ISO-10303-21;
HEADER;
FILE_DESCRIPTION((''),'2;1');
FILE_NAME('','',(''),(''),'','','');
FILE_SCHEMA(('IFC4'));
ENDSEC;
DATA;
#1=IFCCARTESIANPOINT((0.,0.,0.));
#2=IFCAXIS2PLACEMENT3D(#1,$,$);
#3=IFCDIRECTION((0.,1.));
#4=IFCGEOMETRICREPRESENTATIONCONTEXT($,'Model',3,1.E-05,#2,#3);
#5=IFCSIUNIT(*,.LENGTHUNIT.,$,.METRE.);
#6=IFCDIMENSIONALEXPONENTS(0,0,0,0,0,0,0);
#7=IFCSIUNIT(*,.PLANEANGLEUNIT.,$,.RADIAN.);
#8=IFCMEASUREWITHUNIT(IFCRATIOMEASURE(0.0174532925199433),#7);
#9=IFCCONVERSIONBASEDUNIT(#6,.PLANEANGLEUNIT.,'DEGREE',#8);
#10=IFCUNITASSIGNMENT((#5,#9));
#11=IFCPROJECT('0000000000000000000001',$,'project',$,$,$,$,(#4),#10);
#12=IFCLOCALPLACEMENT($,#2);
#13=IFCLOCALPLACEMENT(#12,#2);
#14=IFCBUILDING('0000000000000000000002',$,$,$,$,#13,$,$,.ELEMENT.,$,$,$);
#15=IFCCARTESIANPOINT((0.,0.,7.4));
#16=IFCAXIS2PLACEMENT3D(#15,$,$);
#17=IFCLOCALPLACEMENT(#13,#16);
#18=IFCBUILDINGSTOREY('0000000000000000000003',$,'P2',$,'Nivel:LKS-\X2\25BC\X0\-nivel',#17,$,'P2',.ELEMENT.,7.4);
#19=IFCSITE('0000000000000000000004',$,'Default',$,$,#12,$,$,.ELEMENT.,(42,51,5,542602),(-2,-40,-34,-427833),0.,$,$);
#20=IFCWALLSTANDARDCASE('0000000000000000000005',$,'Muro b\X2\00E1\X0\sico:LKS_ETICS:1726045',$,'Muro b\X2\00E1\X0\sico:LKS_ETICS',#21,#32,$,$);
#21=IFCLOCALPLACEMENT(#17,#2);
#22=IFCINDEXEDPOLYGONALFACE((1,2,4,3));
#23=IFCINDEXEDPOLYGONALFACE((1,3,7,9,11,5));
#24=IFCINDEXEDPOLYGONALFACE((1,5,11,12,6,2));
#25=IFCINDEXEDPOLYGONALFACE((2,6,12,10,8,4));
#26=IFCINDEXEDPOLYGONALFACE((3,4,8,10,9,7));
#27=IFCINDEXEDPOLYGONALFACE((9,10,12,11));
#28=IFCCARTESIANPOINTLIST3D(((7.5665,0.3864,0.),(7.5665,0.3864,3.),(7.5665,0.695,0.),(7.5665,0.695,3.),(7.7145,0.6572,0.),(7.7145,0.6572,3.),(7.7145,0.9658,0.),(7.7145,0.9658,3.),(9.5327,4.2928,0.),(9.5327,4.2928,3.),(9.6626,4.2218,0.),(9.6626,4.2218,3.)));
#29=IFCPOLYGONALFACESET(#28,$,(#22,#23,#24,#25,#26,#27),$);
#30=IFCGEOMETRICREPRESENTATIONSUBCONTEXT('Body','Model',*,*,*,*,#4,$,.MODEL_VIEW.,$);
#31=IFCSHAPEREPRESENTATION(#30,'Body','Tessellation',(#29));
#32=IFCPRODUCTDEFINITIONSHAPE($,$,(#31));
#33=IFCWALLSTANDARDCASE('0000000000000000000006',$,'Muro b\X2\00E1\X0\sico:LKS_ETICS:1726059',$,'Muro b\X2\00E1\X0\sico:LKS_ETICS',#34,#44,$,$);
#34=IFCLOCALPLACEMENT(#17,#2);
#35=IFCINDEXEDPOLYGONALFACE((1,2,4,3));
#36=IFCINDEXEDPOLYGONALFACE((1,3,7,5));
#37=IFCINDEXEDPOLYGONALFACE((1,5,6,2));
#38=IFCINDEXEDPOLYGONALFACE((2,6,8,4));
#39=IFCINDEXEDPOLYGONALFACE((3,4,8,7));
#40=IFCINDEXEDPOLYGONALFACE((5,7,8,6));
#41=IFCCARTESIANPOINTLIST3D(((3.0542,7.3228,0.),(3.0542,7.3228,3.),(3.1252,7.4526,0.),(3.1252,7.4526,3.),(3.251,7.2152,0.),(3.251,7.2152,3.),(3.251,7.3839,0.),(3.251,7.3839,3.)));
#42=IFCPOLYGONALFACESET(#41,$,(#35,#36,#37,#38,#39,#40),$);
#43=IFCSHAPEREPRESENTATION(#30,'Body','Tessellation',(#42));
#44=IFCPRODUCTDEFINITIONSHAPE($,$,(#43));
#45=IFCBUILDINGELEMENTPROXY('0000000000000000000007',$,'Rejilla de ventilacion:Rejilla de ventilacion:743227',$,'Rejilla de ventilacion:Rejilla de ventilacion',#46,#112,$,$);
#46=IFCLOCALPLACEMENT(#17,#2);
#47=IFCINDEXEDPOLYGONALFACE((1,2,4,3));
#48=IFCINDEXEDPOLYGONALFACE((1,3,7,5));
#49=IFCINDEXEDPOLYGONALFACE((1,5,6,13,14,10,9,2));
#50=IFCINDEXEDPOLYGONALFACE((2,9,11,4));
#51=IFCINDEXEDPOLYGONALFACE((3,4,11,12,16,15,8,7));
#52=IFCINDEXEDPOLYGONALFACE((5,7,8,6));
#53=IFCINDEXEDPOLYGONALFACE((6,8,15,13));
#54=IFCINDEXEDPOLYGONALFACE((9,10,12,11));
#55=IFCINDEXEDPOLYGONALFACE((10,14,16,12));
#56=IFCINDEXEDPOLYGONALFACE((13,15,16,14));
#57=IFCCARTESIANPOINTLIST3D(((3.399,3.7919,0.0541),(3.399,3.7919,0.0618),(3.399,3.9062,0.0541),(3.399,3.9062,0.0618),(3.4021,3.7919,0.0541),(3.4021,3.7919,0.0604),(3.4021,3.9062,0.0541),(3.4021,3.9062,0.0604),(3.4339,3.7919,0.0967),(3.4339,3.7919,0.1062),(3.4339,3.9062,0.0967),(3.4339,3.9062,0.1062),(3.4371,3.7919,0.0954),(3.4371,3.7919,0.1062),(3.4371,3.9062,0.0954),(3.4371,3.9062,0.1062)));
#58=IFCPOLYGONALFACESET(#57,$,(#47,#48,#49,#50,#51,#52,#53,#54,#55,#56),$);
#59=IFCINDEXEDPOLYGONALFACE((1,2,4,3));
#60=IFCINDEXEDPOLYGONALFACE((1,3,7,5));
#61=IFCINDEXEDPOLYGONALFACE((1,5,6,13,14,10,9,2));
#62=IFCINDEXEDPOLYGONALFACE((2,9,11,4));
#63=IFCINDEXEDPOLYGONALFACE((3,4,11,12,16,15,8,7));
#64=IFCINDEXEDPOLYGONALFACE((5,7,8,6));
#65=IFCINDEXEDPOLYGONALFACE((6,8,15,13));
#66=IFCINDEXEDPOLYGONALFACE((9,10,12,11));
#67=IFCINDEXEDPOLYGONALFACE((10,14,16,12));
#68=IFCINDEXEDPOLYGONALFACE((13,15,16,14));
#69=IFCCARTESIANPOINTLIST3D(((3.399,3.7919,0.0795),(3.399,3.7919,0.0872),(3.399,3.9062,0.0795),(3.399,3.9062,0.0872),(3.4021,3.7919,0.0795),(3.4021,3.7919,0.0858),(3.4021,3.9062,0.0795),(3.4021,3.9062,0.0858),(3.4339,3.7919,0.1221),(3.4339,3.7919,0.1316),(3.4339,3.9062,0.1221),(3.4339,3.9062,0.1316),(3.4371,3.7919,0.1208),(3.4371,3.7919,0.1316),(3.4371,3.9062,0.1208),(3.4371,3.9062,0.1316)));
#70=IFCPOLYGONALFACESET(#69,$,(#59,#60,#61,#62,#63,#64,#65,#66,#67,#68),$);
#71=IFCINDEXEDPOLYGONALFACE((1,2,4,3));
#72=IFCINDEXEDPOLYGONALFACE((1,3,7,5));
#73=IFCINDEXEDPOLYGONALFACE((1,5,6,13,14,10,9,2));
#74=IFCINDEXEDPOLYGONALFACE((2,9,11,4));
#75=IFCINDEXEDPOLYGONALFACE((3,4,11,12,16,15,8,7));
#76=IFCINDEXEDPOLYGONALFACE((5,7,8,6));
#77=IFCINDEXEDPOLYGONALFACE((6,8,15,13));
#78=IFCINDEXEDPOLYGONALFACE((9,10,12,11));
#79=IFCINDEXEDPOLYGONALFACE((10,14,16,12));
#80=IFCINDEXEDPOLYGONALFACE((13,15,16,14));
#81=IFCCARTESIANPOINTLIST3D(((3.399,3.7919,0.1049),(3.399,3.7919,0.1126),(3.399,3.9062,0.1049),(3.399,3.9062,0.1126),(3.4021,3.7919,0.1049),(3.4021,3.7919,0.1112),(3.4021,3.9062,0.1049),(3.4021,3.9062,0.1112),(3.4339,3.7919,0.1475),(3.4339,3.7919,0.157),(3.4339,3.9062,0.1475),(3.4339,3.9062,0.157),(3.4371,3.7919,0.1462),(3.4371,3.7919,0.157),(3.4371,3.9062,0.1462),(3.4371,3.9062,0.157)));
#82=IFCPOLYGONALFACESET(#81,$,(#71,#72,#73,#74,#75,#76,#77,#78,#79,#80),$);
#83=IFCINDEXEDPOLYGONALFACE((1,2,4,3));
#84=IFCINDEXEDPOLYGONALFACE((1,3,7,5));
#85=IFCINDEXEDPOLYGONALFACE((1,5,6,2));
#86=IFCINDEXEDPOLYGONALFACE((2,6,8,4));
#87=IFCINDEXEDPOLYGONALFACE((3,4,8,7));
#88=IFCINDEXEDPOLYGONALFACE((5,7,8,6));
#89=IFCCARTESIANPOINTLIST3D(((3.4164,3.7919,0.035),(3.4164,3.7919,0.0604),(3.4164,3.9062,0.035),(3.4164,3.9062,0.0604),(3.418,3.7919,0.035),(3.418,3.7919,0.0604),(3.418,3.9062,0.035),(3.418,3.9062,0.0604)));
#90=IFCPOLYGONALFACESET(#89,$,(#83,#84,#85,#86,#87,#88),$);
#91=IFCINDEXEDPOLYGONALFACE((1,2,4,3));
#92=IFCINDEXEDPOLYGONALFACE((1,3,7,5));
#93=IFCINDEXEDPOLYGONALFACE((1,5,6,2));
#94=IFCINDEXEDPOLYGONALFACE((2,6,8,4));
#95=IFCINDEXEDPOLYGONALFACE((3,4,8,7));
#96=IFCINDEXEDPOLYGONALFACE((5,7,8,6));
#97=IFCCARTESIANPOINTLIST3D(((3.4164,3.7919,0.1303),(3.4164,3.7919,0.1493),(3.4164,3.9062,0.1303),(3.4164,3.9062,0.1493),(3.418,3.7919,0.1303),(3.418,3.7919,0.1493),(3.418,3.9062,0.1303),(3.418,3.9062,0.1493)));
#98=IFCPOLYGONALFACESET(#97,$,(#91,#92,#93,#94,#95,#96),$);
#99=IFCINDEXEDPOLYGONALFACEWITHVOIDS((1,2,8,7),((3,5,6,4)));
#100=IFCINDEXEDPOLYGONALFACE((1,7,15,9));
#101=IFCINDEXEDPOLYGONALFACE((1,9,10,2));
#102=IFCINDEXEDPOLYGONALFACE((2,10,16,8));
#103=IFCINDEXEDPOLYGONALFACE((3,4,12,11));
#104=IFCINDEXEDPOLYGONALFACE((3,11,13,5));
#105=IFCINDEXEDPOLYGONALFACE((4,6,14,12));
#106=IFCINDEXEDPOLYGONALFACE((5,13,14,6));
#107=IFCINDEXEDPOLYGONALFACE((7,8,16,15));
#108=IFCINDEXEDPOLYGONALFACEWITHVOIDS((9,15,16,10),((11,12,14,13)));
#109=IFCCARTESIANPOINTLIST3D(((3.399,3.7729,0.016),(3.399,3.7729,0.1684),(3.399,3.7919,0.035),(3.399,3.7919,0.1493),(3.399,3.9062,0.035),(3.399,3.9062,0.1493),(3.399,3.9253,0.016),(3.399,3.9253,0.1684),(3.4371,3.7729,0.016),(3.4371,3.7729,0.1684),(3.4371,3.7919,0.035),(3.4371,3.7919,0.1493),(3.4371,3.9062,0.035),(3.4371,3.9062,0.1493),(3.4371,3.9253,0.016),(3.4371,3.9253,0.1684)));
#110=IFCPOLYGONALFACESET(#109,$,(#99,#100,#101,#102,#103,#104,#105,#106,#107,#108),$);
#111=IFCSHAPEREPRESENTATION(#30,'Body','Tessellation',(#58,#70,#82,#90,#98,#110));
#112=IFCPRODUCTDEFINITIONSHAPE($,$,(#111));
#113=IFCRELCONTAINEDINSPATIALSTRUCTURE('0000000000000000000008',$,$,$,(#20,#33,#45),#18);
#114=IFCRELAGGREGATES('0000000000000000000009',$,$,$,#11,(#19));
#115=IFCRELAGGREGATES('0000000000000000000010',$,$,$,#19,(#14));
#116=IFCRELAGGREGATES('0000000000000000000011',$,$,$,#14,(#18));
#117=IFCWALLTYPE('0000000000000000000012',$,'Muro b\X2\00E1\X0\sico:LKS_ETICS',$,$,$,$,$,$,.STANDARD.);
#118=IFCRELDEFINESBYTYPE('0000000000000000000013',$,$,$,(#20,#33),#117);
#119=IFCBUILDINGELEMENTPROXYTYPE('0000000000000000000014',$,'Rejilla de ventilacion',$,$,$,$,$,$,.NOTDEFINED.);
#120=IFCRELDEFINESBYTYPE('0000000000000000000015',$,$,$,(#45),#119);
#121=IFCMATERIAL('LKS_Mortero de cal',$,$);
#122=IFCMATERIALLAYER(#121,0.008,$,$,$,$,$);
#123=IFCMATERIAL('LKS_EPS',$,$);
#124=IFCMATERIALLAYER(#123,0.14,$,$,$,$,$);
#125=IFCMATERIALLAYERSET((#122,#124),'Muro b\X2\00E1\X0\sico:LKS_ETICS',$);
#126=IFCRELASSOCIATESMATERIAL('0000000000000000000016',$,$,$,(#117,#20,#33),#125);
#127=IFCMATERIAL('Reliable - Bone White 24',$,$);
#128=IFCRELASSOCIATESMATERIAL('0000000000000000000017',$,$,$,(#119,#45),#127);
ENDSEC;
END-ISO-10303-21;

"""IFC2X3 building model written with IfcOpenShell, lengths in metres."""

from ifc_helpers import new_model, entity, si_unit, converted_unit, direction, frame, frame_2d, origin, place, context, subcontext, project, spatial, polyline, rectangle, outline, extrude, source, transform, mapped, material, layer, layer_set, layer_usage, type_object, type_shapes, element, save


model = new_model("IFC2X3")

# Units and contexts
model_context = context("Model", 3, precision=1e-05, world=origin(), true_north=direction((0.0, 1.0)))
body_context = subcontext(model_context, "Body", "Model", "MODEL_VIEW")
ifc_project = project(units=[si_unit("LENGTHUNIT", "METRE"), converted_unit("PLANEANGLEUNIT", "DEGREE", entity("IfcRatioMeasure", 0.0174532925199433), si_unit("PLANEANGLEUNIT", "RADIAN"), dimensions=[0, 0, 0, 0, 0, 0, 0])], contexts=[model_context])

# Site, building, storey
site_placement = place(None, origin())
site = spatial("IfcSite", under=ifc_project, at=site_placement, Name="Default", CompositionType="ELEMENT", RefLatitude=(42, 51, 5, 542602), RefLongitude=(-2, -40, -34, -427833), RefElevation=0.0)
building_placement = place(site_placement, origin())
building = spatial("IfcBuilding", under=site, at=building_placement, CompositionType="ELEMENT")
storey_placement = place(building_placement, frame((0.0, 0.0, 7.4)))
storey = spatial("IfcBuildingStorey", under=building, at=storey_placement, Name="P2", ObjectType="Nivel:LKS-▼-nivel", LongName="P2", CompositionType="ELEMENT", Elevation=7.4)

# Wall
ifc_material_1 = material(Name="LKS_Mortero de cal")
ifc_layer_1 = layer(ifc_material_1, 0.008)
ifc_material_2 = material(Name="LKS_EPS")
ifc_layer_2 = layer(ifc_material_2, 0.14)
ifc_layer_set_1 = layer_set([ifc_layer_1, ifc_layer_2], Name="Muro básico:LKS_ETICS")
ifc_layer_usage_1 = layer_usage(ifc_layer_set_1, "AXIS2", "NEGATIVE", 0.074)
wall_type_1 = type_object("IfcWallType", Name="Muro básico:LKS_ETICS", PredefinedType="STANDARD", material=ifc_layer_set_1)
wall_1_placement = place(storey_placement, frame((9.5977, 4.2573, 0.0), z_axis=(0.0, 0.0, 1.0), x_axis=(-0.479561, -0.877509, 0.0)))
element("IfcWallStandardCase", 1, at=wall_1_placement, inside=storey, type_object=wall_type_1, material=ifc_layer_usage_1, Name="Muro básico:LKS_ETICS:1726045", ObjectType="Muro básico:LKS_ETICS", context=body_context, shape_type="SweptSolid", body=[
    extrude(outline(polyline([(4.1, -0.074), (4.3708, 0.074), (4.0622, 0.074), (0.0, 0.074), (0.0, -0.074), (3.7914, -0.074), (4.1, -0.074)])), origin(), (0.0, 0.0, 1.0), 3.0),
])

# Wall
ifc_layer_usage_2 = layer_usage(ifc_layer_set_1, "AXIS2", "NEGATIVE", 0.074)
wall_2_placement = place(storey_placement, frame((3.2864, 7.2802, 0.0), z_axis=(0.0, 0.0, 1.0), x_axis=(-0.877509, 0.479561, 0.0)))
element("IfcWallStandardCase", 2, at=wall_2_placement, inside=storey, type_object=wall_type_1, material=ifc_layer_usage_2, Name="Muro básico:LKS_ETICS:1726059", ObjectType="Muro básico:LKS_ETICS", context=body_context, shape_type="SweptSolid", body=[
    extrude(outline(polyline([(0.2242, -0.074), (0.2242, 0.074), (0.0, 0.074), (0.0809, -0.074), (0.2242, -0.074)])), origin(), (0.0, 0.0, 1.0), 3.0),
])

# Building element proxy
ifc_material_3 = material(Name="Reliable - Bone White 24")
building_element_proxy_type = type_object("IfcBuildingElementProxyType", Name="Rejilla de ventilacion", PredefinedType="NOTDEFINED", material=ifc_material_3)
shared_shape = source(origin(), body_context, "Body", "SweptSolid", [
    extrude(outline(polyline([(0.0173, 0.0159), (0.0269, 0.0159), (0.0269, 0.0191), (0.016, 0.0191), (-0.0189, -0.0159), (-0.0253, -0.0159), (-0.0253, -0.019), (-0.0176, -0.019), (0.0173, 0.0159)])), frame((-0.0571, 0.1, 1.435), z_axis=(1.0, 0.0, 0.0), x_axis=(0.0, 0.0, 1.0)), (0.0, 0.0, 1.0), 0.1143),
    extrude(outline(polyline([(0.0173, 0.0159), (0.0269, 0.0159), (0.0269, 0.0191), (0.016, 0.0191), (-0.0189, -0.0159), (-0.0253, -0.0159), (-0.0253, -0.019), (-0.0176, -0.019), (0.0173, 0.0159)])), frame((-0.0571, 0.1, 1.4604), z_axis=(1.0, 0.0, 0.0), x_axis=(0.0, 0.0, 1.0)), (0.0, 0.0, 1.0), 0.1143),
    extrude(outline(polyline([(0.0173, 0.0159), (0.0269, 0.0159), (0.0269, 0.0191), (0.016, 0.0191), (-0.0189, -0.0159), (-0.0253, -0.0159), (-0.0253, -0.019), (-0.0176, -0.019), (0.0173, 0.0159)])), frame((-0.0571, 0.1, 1.4858), z_axis=(1.0, 0.0, 0.0), x_axis=(0.0, 0.0, 1.0)), (0.0, 0.0, 1.0), 0.1143),
    extrude(rectangle(XDim=0.1143, YDim=0.0016, at=frame_2d((0.0, 0.0), x_axis=(1.0, 0.0))), frame((0.0, 0.1007, 1.3906), z_axis=(0.0, 0.0, 1.0), x_axis=(-1.0, 0.0, 0.0)), (0.0, 0.0, 1.0), 0.0254),
    extrude(rectangle(XDim=0.1143, YDim=0.0016, at=frame_2d((0.0, 0.0), x_axis=(1.0, 0.0))), frame((0.0, 0.1007, 1.4859), z_axis=(0.0, 0.0, 1.0), x_axis=(-1.0, 0.0, 0.0)), (0.0, 0.0, 1.0), 0.0191),
    extrude(outline(polyline([(-0.0762, -0.0762), (0.0762, -0.0762), (0.0762, 0.0762), (-0.0762, 0.0762), (-0.0762, -0.0762)]), holes=[polyline([(-0.0572, -0.0572), (-0.0572, 0.0572), (0.0572, 0.0572), (0.0572, -0.0572), (-0.0572, -0.0572)])]), frame((0.0, 0.0809, 1.4478), z_axis=(0.0, 1.0, 0.0), x_axis=(0.0, 0.0, 1.0)), (0.0, 0.0, 1.0), 0.0381),
])
type_shapes(building_element_proxy_type, [shared_shape])
proxy_placement = place(storey_placement, frame((3.518, 3.8491, -1.3556), z_axis=(0.0, 0.0, 1.0), x_axis=(0.0, 1.0, 0.0)))
element("IfcBuildingElementProxy", 3, at=proxy_placement, inside=storey, type_object=building_element_proxy_type, material=ifc_material_3, Name="Rejilla de ventilacion:Rejilla de ventilacion:743227", ObjectType="Rejilla de ventilacion:Rejilla de ventilacion", context=body_context, shape_type="MappedRepresentation", body=[
    mapped(shared_shape, transform((0.0, 0.0, 0.0), scale=1.0)),
])

save(model, "model.ifc")
